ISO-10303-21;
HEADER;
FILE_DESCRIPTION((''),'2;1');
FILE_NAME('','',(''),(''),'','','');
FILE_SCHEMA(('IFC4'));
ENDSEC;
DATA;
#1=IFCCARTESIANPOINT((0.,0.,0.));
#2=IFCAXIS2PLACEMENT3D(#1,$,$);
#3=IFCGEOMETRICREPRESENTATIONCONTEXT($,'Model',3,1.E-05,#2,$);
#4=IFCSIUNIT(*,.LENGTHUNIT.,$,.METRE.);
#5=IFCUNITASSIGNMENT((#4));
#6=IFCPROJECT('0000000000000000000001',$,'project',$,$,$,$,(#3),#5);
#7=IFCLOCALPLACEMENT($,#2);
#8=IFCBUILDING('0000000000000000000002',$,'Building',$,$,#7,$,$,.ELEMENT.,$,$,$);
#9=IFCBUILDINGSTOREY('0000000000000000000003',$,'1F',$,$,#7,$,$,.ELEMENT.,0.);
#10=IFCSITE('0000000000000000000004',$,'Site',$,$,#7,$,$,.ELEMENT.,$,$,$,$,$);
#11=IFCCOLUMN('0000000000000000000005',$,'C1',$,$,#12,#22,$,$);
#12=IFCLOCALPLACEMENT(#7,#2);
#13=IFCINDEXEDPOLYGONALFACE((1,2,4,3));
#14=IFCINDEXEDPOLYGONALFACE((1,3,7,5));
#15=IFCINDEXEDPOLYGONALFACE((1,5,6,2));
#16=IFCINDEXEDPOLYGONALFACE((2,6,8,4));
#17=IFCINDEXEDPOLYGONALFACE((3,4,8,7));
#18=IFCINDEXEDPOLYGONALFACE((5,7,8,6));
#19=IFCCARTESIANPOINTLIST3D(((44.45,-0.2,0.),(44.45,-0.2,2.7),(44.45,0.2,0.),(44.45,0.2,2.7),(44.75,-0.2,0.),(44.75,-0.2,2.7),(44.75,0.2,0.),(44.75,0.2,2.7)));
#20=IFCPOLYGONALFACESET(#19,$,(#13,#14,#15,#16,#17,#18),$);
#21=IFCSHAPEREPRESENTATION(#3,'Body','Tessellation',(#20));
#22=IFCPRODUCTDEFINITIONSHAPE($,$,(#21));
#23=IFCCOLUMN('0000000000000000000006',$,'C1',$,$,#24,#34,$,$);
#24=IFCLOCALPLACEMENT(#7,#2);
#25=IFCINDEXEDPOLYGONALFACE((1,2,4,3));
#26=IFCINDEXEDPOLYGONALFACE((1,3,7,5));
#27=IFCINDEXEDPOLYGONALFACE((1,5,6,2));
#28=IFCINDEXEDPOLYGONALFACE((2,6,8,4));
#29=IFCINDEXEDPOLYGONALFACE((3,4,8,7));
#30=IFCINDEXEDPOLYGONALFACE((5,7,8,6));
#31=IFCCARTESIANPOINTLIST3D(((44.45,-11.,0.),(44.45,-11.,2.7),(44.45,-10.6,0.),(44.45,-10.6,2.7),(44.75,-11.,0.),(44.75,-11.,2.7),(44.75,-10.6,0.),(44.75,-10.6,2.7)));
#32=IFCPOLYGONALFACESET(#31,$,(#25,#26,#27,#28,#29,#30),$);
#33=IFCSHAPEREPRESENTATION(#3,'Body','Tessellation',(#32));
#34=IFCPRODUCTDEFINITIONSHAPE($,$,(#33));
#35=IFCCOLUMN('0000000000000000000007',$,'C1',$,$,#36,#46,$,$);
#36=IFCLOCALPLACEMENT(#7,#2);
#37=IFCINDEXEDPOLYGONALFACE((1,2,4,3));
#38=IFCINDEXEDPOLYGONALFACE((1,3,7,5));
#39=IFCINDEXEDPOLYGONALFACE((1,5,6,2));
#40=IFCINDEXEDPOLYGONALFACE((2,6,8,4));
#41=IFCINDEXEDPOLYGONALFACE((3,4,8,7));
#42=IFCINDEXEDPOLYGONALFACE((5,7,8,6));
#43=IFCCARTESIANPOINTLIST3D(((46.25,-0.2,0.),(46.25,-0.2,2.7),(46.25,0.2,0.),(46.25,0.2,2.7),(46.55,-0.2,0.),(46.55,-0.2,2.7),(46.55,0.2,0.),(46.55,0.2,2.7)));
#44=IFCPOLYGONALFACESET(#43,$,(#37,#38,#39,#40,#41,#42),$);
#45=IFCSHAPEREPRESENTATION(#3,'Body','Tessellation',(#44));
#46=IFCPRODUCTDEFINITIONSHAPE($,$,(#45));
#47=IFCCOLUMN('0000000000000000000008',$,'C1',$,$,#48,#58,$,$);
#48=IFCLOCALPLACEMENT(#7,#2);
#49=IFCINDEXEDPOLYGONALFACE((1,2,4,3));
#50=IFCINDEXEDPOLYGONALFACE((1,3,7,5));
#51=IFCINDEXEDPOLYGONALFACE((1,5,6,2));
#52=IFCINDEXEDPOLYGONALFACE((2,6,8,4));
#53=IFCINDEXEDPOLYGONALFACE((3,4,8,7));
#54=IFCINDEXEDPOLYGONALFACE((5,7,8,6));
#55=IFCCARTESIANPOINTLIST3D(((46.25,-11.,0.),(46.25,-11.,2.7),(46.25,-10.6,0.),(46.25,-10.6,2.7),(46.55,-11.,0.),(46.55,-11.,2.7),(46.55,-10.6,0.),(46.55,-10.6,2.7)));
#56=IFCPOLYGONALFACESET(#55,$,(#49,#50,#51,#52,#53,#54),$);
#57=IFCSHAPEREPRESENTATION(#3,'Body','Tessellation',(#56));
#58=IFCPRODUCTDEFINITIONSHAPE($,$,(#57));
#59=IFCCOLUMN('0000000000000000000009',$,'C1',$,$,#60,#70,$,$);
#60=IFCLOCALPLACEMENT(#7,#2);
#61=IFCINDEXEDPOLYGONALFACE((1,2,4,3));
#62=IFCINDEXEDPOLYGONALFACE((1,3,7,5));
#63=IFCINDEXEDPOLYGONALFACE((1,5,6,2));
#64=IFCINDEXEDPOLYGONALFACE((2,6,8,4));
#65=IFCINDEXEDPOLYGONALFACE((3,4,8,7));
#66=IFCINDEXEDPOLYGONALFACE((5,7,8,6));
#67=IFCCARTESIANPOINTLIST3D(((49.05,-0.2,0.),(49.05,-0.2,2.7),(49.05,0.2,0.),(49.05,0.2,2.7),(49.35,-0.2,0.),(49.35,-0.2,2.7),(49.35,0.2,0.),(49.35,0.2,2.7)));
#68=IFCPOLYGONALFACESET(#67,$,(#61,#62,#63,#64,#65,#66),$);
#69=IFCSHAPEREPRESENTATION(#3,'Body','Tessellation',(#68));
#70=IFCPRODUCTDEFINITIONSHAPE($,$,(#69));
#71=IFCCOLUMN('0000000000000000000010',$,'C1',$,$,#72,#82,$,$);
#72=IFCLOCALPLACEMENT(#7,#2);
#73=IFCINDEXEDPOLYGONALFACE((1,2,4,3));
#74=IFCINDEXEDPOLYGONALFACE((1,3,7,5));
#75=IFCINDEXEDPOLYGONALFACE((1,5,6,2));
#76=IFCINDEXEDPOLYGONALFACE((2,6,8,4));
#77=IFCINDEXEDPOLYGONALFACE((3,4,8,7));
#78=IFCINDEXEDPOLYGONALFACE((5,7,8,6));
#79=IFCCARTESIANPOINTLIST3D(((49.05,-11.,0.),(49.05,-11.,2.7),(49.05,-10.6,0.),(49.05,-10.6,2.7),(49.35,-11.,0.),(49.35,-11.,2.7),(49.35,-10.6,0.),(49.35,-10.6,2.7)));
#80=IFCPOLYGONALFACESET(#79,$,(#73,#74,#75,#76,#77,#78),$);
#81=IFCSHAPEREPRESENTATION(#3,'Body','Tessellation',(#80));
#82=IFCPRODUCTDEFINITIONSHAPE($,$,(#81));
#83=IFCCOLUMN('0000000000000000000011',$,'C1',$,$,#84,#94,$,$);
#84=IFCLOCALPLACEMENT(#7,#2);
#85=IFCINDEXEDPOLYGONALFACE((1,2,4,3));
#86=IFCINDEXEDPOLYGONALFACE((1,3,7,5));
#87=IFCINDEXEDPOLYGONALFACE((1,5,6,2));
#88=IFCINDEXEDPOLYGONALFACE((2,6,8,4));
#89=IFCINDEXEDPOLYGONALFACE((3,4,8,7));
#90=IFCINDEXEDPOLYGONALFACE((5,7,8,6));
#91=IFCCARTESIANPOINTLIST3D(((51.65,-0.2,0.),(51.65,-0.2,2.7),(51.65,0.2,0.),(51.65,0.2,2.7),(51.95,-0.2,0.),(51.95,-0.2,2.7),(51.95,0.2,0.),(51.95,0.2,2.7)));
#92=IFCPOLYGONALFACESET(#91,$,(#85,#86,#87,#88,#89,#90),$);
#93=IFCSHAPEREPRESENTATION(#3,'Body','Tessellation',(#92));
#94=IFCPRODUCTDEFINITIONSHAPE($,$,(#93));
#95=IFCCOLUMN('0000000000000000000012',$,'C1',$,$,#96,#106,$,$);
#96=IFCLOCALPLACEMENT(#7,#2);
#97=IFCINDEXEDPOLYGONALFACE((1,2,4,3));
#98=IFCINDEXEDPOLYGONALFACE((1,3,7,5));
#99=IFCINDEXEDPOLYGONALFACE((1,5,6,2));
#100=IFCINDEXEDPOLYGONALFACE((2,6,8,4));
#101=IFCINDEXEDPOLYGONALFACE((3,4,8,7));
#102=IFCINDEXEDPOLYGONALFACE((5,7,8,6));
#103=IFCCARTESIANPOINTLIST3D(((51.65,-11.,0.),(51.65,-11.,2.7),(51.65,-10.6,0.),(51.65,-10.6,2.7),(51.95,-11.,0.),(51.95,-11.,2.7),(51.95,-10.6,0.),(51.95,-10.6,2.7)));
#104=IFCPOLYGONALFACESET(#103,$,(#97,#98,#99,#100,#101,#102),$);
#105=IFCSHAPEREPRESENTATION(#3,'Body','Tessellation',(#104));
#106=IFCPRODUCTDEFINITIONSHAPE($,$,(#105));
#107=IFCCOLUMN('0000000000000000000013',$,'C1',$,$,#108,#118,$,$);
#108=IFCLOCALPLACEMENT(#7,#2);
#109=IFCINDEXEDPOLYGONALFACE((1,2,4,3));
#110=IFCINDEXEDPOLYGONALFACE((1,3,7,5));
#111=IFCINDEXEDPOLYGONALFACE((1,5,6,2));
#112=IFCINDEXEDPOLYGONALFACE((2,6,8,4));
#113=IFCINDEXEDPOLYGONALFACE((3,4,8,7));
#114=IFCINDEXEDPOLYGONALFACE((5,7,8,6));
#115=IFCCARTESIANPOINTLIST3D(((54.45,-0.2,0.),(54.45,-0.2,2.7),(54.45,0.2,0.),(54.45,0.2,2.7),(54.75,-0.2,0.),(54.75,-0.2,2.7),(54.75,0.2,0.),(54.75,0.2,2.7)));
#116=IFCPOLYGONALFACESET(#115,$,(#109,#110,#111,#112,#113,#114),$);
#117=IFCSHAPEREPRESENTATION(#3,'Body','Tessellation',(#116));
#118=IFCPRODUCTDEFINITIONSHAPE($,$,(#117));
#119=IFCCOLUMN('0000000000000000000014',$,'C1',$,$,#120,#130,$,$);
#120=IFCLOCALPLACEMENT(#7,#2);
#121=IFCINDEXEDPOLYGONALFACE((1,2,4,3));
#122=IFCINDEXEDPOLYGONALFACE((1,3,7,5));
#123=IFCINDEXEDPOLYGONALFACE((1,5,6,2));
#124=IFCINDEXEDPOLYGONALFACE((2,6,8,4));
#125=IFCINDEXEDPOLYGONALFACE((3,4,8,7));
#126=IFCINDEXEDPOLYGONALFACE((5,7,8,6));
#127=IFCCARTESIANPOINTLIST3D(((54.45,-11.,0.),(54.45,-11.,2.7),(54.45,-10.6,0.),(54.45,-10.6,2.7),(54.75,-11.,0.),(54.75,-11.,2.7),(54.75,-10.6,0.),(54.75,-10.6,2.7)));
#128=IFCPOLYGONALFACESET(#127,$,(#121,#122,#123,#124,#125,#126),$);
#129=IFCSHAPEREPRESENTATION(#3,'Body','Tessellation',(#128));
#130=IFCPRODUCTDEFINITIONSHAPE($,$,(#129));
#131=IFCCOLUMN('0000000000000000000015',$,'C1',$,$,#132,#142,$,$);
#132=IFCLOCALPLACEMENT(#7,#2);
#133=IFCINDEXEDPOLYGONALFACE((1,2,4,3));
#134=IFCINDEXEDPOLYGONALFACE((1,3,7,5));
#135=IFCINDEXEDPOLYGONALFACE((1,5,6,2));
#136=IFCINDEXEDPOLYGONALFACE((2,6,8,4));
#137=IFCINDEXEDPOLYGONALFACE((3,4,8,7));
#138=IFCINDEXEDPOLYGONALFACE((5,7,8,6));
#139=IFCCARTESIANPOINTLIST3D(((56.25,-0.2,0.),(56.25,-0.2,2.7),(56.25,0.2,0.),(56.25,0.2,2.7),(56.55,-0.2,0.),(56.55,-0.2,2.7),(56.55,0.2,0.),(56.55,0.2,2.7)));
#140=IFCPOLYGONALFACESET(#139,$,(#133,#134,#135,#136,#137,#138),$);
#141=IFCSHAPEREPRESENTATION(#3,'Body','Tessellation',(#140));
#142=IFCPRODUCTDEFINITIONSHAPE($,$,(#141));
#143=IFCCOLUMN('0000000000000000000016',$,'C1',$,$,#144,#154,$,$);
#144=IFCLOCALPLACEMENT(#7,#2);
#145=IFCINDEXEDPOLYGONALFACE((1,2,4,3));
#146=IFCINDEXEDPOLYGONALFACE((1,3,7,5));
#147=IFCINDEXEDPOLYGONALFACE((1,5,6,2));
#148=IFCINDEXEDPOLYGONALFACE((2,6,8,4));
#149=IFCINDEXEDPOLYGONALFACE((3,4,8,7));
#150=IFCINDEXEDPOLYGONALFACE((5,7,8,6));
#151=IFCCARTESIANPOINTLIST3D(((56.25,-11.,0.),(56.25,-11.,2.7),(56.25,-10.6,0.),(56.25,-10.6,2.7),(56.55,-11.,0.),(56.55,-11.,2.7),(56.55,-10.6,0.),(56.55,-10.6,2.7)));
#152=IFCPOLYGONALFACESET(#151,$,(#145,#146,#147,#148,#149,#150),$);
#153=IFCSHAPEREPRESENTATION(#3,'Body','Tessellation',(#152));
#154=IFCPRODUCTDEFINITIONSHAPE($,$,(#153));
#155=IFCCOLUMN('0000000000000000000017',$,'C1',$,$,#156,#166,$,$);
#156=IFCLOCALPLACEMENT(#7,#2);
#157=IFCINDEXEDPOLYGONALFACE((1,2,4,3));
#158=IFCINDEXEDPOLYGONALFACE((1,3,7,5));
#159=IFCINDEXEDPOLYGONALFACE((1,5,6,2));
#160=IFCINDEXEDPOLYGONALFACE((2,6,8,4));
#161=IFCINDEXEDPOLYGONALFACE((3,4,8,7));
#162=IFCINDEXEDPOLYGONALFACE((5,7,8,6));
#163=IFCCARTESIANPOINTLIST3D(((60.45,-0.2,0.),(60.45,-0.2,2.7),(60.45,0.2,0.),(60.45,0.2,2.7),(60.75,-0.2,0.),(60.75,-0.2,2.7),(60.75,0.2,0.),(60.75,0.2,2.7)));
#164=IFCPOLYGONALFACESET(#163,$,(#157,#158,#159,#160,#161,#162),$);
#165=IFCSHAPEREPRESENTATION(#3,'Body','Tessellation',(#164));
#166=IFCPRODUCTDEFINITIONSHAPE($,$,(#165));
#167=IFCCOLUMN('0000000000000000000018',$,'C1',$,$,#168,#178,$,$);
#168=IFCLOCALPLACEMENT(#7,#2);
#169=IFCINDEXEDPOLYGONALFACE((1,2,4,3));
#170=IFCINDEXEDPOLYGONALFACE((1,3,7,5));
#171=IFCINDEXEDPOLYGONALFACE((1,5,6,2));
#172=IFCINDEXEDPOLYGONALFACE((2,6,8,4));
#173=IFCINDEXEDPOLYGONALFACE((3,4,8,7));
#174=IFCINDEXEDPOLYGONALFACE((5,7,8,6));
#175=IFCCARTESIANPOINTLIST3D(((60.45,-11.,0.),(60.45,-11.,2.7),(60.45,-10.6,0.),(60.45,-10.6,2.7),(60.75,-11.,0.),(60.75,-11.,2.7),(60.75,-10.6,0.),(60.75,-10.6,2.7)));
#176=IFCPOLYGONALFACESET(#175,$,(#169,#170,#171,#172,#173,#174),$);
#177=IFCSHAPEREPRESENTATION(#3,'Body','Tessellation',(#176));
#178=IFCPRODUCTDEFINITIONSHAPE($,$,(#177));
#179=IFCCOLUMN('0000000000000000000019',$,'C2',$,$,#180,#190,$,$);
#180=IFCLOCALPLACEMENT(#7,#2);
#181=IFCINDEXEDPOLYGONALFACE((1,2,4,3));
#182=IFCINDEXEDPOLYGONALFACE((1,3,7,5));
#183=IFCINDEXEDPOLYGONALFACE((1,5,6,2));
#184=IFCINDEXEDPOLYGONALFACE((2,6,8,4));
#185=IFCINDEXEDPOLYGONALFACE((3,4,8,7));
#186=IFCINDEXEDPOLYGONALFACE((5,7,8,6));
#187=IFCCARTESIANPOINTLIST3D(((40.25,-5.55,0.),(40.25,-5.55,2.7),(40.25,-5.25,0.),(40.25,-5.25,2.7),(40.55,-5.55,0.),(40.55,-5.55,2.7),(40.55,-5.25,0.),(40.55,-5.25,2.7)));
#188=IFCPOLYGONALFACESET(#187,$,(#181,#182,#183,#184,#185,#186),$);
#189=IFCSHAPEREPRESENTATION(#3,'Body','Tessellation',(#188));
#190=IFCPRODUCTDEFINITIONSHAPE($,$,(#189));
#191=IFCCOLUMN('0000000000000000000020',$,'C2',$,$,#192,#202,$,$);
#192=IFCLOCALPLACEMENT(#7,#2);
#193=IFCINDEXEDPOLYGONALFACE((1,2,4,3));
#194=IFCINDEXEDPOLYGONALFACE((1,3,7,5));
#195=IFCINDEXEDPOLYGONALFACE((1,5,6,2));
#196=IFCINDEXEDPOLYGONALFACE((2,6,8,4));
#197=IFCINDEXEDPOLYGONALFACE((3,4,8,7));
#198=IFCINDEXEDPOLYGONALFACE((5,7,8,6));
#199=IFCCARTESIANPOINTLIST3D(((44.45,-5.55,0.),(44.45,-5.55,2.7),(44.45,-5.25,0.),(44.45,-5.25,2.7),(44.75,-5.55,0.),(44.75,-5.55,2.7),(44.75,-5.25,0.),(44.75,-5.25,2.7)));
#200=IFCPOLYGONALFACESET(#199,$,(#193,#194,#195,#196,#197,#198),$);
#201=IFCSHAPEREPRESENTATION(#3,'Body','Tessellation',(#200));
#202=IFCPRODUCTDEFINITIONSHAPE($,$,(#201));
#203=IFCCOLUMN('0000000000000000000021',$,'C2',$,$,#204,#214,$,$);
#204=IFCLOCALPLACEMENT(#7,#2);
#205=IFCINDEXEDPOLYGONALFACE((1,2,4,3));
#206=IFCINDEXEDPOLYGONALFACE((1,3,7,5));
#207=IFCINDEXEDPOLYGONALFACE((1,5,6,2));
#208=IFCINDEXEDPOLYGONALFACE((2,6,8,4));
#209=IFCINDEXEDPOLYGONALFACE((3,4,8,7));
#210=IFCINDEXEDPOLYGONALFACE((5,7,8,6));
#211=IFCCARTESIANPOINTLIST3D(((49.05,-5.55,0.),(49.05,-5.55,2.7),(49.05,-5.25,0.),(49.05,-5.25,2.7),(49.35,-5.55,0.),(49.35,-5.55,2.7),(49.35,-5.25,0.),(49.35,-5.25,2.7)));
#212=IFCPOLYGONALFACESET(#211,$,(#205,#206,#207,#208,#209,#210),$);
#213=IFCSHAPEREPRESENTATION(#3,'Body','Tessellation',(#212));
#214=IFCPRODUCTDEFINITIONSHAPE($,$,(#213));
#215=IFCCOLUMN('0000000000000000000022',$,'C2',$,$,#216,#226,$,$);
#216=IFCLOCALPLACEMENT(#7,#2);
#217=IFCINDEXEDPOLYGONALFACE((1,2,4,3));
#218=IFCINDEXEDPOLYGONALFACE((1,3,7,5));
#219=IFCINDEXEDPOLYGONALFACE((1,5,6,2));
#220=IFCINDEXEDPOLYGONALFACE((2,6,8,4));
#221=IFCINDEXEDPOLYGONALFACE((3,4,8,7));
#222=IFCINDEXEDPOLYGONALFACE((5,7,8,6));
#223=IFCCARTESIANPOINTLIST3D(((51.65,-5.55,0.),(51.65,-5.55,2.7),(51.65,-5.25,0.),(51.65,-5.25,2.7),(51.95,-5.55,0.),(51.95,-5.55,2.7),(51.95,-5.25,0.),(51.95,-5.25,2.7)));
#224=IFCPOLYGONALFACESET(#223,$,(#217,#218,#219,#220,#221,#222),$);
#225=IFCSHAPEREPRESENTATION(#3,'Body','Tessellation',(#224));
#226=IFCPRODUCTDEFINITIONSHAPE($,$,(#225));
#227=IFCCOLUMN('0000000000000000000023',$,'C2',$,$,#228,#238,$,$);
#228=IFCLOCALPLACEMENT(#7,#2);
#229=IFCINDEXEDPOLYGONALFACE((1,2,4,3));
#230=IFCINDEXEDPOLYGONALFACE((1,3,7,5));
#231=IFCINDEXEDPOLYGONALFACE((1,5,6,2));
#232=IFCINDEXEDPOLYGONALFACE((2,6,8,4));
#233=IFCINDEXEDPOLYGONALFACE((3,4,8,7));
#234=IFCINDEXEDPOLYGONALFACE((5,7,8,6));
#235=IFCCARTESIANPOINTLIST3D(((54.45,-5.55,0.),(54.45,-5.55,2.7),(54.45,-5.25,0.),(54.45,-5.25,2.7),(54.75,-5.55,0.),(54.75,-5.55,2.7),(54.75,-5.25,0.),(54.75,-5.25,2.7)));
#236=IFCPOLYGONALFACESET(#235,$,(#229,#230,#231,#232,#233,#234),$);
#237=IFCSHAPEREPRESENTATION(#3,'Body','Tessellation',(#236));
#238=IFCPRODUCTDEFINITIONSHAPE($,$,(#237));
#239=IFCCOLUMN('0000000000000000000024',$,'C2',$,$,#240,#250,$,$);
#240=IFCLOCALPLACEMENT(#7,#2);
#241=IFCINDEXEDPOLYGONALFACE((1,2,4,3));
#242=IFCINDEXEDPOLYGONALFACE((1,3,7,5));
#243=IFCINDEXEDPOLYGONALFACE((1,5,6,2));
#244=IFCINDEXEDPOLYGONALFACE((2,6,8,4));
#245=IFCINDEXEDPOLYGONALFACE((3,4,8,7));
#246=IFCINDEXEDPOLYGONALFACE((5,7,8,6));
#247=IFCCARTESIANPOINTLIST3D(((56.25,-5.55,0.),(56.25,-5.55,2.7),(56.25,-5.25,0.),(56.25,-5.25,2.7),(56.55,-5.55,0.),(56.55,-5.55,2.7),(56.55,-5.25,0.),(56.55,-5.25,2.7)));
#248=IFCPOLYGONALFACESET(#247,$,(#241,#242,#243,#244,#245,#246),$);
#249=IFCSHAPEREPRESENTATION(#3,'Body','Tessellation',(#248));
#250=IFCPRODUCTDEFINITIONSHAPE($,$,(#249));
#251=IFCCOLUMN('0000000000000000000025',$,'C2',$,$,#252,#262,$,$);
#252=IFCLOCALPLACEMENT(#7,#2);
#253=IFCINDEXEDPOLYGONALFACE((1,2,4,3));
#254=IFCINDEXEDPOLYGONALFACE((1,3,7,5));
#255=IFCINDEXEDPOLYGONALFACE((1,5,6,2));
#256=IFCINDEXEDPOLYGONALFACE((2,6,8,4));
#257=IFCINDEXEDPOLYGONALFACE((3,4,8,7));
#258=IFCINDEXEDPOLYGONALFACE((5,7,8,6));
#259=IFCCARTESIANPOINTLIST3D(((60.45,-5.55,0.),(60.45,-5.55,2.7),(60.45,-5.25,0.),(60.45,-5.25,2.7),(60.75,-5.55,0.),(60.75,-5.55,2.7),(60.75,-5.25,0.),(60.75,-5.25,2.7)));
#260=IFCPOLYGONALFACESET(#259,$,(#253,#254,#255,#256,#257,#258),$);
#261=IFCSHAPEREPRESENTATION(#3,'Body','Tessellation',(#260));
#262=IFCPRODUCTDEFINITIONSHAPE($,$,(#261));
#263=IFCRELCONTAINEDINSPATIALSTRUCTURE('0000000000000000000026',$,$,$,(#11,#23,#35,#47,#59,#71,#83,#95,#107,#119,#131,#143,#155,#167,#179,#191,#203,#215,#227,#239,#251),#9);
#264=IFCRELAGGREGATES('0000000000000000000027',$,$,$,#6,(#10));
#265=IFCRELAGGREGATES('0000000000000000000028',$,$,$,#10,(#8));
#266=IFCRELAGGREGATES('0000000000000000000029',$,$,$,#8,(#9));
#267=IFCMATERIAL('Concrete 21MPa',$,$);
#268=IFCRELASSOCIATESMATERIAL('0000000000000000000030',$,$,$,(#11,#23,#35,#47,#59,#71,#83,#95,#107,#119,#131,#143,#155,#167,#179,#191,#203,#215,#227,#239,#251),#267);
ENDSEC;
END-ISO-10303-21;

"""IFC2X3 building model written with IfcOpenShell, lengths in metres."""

from ifc_helpers import new_model, si_unit, frame, origin, origin_2d, place, context, project, spatial, rectangle, extrude, material, element, save


model = new_model("IFC2X3")

# Units and contexts
model_context = context("Model", 3, precision=1e-05, world=origin())
ifc_project = project(units=[si_unit("LENGTHUNIT", "METRE")], contexts=[model_context])

# Site, building, storey
placement = place(None, origin())
site = spatial("IfcSite", under=ifc_project, at=placement, Name="Site", CompositionType="ELEMENT")
building = spatial("IfcBuilding", under=site, at=placement, Name="Building", CompositionType="ELEMENT")
storey = spatial("IfcBuildingStorey", under=building, at=placement, Name="1F", CompositionType="ELEMENT", Elevation=0.0)

# Columns
ifc_material = material(Name="Concrete 21MPa")
for number, where, name in (
    (1, (44.6, 0.0, 0.0), "C1"),
    (2, (44.6, -10.8, 0.0), "C1"),
    (3, (46.4, 0.0, 0.0), "C1"),
    (4, (46.4, -10.8, 0.0), "C1"),
    (5, (49.2, 0.0, 0.0), "C1"),
    (6, (49.2, -10.8, 0.0), "C1"),
    (7, (51.8, 0.0, 0.0), "C1"),
    (8, (51.8, -10.8, 0.0), "C1"),
    (9, (54.6, 0.0, 0.0), "C1"),
    (10, (54.6, -10.8, 0.0), "C1"),
    (11, (56.4, 0.0, 0.0), "C1"),
    (12, (56.4, -10.8, 0.0), "C1"),
    (13, (60.6, 0.0, 0.0), "C1"),
    (14, (60.6, -10.8, 0.0), "C1"),
):
    element("IfcColumn", number, at=place(None, frame(where)), inside=storey, material=ifc_material, Name=name, context=model_context, shape_type="SweptSolid", body=[
        extrude(rectangle(XDim=0.3, YDim=0.4, at=origin_2d()), origin(), (0.0, 0.0, 1.0), 2.7),
    ])
for number, where, name in (
    (15, (40.4, -5.4, 0.0), "C2"),
    (16, (44.6, -5.4, 0.0), "C2"),
    (17, (49.2, -5.4, 0.0), "C2"),
    (18, (51.8, -5.4, 0.0), "C2"),
    (19, (54.6, -5.4, 0.0), "C2"),
    (20, (56.4, -5.4, 0.0), "C2"),
    (21, (60.6, -5.4, 0.0), "C2"),
):
    element("IfcColumn", number, at=place(None, frame(where)), inside=storey, material=ifc_material, Name=name, context=model_context, shape_type="SweptSolid", body=[
        extrude(rectangle(XDim=0.3, YDim=0.3, at=origin_2d()), origin(), (0.0, 0.0, 1.0), 2.7),
    ])

save(model, "model.ifc")
